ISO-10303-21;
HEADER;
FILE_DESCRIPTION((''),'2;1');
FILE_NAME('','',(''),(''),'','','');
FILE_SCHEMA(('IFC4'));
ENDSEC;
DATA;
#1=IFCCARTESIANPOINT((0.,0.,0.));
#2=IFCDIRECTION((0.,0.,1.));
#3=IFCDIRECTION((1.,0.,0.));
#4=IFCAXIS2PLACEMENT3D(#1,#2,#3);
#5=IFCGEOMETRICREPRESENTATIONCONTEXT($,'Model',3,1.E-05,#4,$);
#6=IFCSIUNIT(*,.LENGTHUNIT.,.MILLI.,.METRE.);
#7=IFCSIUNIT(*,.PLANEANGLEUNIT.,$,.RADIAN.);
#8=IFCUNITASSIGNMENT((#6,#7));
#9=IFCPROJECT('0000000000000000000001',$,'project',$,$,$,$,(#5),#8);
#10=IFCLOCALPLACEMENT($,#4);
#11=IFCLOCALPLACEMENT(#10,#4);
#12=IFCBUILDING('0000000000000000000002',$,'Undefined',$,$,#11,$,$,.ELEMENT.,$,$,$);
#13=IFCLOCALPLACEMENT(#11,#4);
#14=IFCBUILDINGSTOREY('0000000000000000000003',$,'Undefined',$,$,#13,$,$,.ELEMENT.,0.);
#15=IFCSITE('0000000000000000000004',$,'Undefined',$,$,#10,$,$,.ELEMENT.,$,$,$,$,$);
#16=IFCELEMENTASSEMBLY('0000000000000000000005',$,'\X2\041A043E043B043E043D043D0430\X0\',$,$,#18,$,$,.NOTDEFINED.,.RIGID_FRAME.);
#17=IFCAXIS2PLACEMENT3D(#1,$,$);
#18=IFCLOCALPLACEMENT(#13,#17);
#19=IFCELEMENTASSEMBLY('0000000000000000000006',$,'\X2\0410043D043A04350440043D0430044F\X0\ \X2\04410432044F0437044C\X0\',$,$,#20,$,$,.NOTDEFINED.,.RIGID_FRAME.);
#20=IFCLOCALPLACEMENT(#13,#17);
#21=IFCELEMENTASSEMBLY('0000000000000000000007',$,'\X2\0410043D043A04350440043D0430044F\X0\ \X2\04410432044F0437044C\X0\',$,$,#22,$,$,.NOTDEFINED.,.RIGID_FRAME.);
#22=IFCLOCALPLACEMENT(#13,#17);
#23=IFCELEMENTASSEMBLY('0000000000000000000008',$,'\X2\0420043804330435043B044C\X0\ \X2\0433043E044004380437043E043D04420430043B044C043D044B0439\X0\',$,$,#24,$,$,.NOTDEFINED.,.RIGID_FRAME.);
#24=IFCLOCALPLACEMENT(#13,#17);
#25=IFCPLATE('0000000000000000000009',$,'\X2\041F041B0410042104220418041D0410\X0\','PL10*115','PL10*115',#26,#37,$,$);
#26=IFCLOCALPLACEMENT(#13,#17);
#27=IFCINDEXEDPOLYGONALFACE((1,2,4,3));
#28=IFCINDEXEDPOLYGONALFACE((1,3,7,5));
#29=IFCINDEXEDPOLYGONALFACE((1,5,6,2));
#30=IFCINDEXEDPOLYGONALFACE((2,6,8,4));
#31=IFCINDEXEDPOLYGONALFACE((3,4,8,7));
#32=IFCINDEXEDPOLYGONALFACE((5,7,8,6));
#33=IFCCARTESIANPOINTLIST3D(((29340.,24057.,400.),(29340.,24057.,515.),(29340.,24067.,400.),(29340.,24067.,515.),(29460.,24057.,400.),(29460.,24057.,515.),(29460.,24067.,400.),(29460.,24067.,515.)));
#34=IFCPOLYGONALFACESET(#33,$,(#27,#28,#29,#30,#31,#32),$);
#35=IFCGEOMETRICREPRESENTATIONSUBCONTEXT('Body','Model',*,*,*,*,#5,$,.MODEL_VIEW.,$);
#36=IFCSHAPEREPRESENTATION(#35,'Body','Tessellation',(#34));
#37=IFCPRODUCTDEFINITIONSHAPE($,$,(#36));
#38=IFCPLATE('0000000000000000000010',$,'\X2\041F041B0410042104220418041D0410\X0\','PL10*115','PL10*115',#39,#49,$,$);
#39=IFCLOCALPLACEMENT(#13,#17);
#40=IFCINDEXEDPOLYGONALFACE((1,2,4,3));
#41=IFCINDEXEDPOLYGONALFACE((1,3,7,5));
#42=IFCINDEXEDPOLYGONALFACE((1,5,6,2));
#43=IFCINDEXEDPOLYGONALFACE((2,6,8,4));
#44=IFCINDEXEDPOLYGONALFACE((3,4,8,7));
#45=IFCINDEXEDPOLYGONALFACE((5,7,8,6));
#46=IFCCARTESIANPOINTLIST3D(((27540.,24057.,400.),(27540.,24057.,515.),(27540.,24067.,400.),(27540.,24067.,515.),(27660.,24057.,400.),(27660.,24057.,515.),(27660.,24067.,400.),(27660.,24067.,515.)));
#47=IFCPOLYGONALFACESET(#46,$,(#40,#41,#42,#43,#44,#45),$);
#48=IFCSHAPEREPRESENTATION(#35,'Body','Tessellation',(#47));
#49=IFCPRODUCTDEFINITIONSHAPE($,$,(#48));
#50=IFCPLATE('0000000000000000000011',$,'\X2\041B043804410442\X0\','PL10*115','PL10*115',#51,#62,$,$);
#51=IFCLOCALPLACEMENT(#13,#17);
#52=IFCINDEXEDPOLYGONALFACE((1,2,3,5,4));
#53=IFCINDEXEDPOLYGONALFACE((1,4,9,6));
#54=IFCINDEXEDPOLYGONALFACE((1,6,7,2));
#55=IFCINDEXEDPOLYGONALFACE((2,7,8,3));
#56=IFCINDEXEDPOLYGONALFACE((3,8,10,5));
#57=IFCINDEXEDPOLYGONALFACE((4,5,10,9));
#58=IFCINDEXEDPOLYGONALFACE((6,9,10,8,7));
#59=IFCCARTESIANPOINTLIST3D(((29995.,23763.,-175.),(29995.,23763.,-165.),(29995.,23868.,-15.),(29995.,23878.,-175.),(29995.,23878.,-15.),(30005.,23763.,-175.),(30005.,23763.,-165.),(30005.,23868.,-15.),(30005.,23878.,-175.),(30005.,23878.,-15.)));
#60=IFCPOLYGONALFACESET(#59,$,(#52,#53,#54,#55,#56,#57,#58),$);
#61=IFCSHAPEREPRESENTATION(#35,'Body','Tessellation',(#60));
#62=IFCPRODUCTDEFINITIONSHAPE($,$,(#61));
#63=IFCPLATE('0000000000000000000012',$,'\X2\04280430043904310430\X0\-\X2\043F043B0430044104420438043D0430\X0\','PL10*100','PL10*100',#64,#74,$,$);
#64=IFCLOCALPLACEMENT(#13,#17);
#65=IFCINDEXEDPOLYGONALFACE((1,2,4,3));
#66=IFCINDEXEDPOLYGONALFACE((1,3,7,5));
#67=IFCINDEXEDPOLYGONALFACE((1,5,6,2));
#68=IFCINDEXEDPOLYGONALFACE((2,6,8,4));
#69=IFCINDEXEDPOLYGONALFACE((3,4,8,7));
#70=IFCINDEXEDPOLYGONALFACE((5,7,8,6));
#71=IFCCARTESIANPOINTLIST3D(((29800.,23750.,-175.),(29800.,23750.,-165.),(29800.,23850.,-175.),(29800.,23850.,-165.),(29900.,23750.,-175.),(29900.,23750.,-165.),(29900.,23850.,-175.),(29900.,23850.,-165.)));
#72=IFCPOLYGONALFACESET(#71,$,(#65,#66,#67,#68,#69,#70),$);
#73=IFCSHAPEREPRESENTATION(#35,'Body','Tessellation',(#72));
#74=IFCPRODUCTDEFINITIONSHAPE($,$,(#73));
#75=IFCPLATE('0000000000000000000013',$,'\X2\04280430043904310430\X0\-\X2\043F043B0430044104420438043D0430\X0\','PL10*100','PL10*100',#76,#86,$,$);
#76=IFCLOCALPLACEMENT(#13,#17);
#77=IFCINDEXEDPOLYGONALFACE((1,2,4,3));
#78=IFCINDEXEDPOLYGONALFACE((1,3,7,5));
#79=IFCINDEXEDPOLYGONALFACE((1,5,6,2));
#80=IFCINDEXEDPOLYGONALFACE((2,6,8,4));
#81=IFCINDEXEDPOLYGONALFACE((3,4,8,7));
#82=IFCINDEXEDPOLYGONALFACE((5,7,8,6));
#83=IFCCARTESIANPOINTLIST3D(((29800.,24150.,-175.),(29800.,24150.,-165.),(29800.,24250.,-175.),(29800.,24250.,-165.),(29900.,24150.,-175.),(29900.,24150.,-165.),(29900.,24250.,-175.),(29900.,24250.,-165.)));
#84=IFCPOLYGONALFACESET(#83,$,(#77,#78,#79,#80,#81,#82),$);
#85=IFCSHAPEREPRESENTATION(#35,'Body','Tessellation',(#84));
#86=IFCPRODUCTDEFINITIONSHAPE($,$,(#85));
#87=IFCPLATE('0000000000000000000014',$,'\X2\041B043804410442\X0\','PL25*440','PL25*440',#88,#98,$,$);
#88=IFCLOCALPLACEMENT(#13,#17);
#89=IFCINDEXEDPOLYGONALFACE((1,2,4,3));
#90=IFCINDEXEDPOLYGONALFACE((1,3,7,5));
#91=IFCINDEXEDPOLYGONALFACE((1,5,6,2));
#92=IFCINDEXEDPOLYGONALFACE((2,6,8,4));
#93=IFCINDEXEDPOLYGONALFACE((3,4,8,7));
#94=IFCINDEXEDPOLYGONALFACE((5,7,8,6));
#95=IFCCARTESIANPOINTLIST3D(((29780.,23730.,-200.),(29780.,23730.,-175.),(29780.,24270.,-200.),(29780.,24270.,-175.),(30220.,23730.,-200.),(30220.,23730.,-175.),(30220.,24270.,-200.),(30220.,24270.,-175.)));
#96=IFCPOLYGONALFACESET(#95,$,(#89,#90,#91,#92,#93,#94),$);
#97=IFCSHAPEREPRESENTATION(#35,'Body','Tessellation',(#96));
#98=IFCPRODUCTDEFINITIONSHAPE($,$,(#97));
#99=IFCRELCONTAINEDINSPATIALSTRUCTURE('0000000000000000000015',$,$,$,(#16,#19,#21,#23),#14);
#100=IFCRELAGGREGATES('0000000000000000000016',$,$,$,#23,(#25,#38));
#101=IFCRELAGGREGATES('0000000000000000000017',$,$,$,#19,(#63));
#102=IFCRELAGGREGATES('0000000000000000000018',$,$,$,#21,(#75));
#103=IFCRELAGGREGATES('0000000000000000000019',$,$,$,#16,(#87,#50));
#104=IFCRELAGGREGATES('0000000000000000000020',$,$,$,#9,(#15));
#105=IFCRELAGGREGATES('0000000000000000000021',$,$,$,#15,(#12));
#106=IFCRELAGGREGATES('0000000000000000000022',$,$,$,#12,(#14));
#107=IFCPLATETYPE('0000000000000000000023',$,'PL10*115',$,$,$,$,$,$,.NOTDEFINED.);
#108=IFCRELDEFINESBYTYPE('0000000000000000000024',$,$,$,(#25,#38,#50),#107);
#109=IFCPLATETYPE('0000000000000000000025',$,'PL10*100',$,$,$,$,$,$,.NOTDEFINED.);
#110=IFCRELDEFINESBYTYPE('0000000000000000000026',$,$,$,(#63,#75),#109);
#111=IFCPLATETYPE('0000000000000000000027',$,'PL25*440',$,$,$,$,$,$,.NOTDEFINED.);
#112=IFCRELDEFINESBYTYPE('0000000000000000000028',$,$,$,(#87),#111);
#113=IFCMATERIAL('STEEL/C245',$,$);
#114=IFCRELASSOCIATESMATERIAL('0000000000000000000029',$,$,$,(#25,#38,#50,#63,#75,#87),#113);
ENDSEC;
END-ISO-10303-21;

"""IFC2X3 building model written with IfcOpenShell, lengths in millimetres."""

from ifc_helpers import new_model, si_unit, frame, origin_with_axes, place, context, subcontext, project, spatial, polyline, outline, extrude, material, type_object, element, aggregate, save


model = new_model("IFC2X3")

# Units and contexts
model_context = context("Model", 3, precision=1e-05, world=origin_with_axes())
body_context = subcontext(model_context, "Body", "Model", "MODEL_VIEW")
ifc_project = project(units=[si_unit("LENGTHUNIT", "METRE", prefix="MILLI"), si_unit("PLANEANGLEUNIT", "RADIAN")], contexts=[model_context])

# Site, building, storey
site_placement = place(None, origin_with_axes())
site = spatial("IfcSite", under=ifc_project, at=site_placement, Name="Undefined", CompositionType="ELEMENT")
building_placement = place(site_placement, origin_with_axes())
building = spatial("IfcBuilding", under=site, at=building_placement, Name="Undefined", CompositionType="ELEMENT")
storey_placement = place(building_placement, origin_with_axes())
storey = spatial("IfcBuildingStorey", under=building, at=storey_placement, Name="Undefined", CompositionType="ELEMENT", Elevation=0.0)

# Element assembly
ifc_material_1 = material(Name="STEEL/C245")
assembly_1_placement = place(storey_placement, origin_with_axes())
assembly_1 = element("IfcElementAssembly", 1, at=assembly_1_placement, inside=storey, Name="Колонна", AssemblyPlace="NOTDEFINED", PredefinedType="RIGID_FRAME")

# Element assemblies
assembly_2_placement = place(storey_placement, origin_with_axes())
assembly_2 = element("IfcElementAssembly", 2, at=assembly_2_placement, inside=storey, Name="Анкерная связь", AssemblyPlace="NOTDEFINED", PredefinedType="RIGID_FRAME")
assembly_3_placement = place(storey_placement, origin_with_axes())
assembly_3 = element("IfcElementAssembly", 3, at=assembly_3_placement, inside=storey, Name="Анкерная связь", AssemblyPlace="NOTDEFINED", PredefinedType="RIGID_FRAME")

# Element assembly, plates
assembly_4_placement = place(storey_placement, origin_with_axes())
assembly_4 = element("IfcElementAssembly", 4, at=assembly_4_placement, inside=storey, Name="Ригель горизонтальный", AssemblyPlace="NOTDEFINED", PredefinedType="RIGID_FRAME")
plate_type_1 = type_object("IfcPlateType", Name="PL10*115", PredefinedType="NOTDEFINED")
plate_1_placement = place(assembly_4_placement, frame((29460.0, 24062.0, 400.0), z_axis=(0.0, -1.0, 0.0), x_axis=(0.0, 0.0, 1.0)))
plate_1 = element("IfcPlate", 5, at=plate_1_placement, type_object=plate_type_1, material=ifc_material_1, Name="ПЛАСТИНА", Description="PL10*115", ObjectType="PL10*115", context=body_context, shape_type="SweptSolid", body=[
    extrude(outline(polyline([(0.0, 0.0), (115.0, 0.0), (115.0, 120.0), (0.0, 120.0), (0.0, 0.0)])), frame((0.0, 0.0, -5.0), z_axis=(0.0, 0.0, 1.0), x_axis=(1.0, 0.0, 0.0)), (0.0, 0.0, 1.0), 10.0),
])
plate_2_placement = place(assembly_4_placement, frame((27660.0, 24062.0, 400.0), z_axis=(0.0, -1.0, 0.0), x_axis=(0.0, 0.0, 1.0)))
plate_2 = element("IfcPlate", 6, at=plate_2_placement, type_object=plate_type_1, material=ifc_material_1, Name="ПЛАСТИНА", Description="PL10*115", ObjectType="PL10*115", context=body_context, shape_type="SweptSolid", body=[
    extrude(outline(polyline([(0.0, 0.0), (115.0, 0.0), (115.0, 120.0), (0.0, 120.0), (0.0, 0.0)])), frame((0.0, 0.0, -5.0), z_axis=(0.0, 0.0, 1.0), x_axis=(1.0, 0.0, 0.0)), (0.0, 0.0, 1.0), 10.0),
])

# Plates
plate_3_placement = place(assembly_1_placement, frame((30000.0, 23878.0, -15.0), z_axis=(-1.0, 0.0, 0.0), x_axis=(0.0, 0.0, -1.0)))
plate_3 = element("IfcPlate", 7, at=plate_3_placement, type_object=plate_type_1, material=ifc_material_1, Name="Лист", Description="PL10*115", ObjectType="PL10*115", context=body_context, shape_type="SweptSolid", body=[
    extrude(outline(polyline([(0.0, 0.0), (160.0, 0.0), (160.0, 115.0), (150.0, 115.0), (0.0, 10.0), (0.0, 0.0)])), frame((0.0, 0.0, -5.0), z_axis=(0.0, 0.0, 1.0), x_axis=(1.0, 0.0, 0.0)), (0.0, 0.0, 1.0), 10.0),
])
plate_type_2 = type_object("IfcPlateType", Name="PL10*100", PredefinedType="NOTDEFINED")
plate_4_placement = place(assembly_2_placement, frame((29900.0, 23850.0, -170.0), z_axis=(0.0, 0.0, -1.0), x_axis=(0.0, -1.0, 0.0)))
plate_4 = element("IfcPlate", 8, at=plate_4_placement, type_object=plate_type_2, material=ifc_material_1, Name="Шайба-пластина", Description="PL10*100", ObjectType="PL10*100", context=body_context, shape_type="SweptSolid", body=[
    extrude(outline(polyline([(0.0, 0.0), (100.0, 0.0), (100.0, 100.0), (0.0, 100.0), (0.0, 0.0)])), frame((0.0, 0.0, -5.0), z_axis=(0.0, 0.0, 1.0), x_axis=(1.0, 0.0, 0.0)), (0.0, 0.0, 1.0), 10.0),
])
plate_5_placement = place(assembly_3_placement, frame((29900.0, 24250.0, -170.0), z_axis=(0.0, 0.0, -1.0), x_axis=(0.0, -1.0, 0.0)))
plate_5 = element("IfcPlate", 9, at=plate_5_placement, type_object=plate_type_2, material=ifc_material_1, Name="Шайба-пластина", Description="PL10*100", ObjectType="PL10*100", context=body_context, shape_type="SweptSolid", body=[
    extrude(outline(polyline([(0.0, 0.0), (100.0, 0.0), (100.0, 100.0), (0.0, 100.0), (0.0, 0.0)])), frame((0.0, 0.0, -5.0), z_axis=(0.0, 0.0, 1.0), x_axis=(1.0, 0.0, 0.0)), (0.0, 0.0, 1.0), 10.0),
])
plate_type_3 = type_object("IfcPlateType", Name="PL25*440", PredefinedType="NOTDEFINED")
plate_6_placement = place(assembly_1_placement, frame((30000.0, 23730.0, -187.5), z_axis=(0.0, 0.0, 1.0), x_axis=(0.0, 1.0, 0.0)))
plate_6 = element("IfcPlate", 10, at=plate_6_placement, type_object=plate_type_3, material=ifc_material_1, Name="Лист", Description="PL25*440", ObjectType="PL25*440", context=body_context, shape_type="SweptSolid", body=[
    extrude(outline(polyline([(0.0, 220.0), (540.0, 220.0), (540.0, -220.0), (0.0, -220.0), (0.0, 220.0)])), frame((0.0, 0.0, -12.5), z_axis=(0.0, 0.0, 1.0), x_axis=(1.0, 0.0, 0.0)), (0.0, 0.0, 1.0), 25.0),
])

aggregate(assembly_4, [plate_1, plate_2])
aggregate(assembly_2, [plate_4])
aggregate(assembly_3, [plate_5])
aggregate(assembly_1, [plate_6, plate_3])

save(model, "model.ifc")
